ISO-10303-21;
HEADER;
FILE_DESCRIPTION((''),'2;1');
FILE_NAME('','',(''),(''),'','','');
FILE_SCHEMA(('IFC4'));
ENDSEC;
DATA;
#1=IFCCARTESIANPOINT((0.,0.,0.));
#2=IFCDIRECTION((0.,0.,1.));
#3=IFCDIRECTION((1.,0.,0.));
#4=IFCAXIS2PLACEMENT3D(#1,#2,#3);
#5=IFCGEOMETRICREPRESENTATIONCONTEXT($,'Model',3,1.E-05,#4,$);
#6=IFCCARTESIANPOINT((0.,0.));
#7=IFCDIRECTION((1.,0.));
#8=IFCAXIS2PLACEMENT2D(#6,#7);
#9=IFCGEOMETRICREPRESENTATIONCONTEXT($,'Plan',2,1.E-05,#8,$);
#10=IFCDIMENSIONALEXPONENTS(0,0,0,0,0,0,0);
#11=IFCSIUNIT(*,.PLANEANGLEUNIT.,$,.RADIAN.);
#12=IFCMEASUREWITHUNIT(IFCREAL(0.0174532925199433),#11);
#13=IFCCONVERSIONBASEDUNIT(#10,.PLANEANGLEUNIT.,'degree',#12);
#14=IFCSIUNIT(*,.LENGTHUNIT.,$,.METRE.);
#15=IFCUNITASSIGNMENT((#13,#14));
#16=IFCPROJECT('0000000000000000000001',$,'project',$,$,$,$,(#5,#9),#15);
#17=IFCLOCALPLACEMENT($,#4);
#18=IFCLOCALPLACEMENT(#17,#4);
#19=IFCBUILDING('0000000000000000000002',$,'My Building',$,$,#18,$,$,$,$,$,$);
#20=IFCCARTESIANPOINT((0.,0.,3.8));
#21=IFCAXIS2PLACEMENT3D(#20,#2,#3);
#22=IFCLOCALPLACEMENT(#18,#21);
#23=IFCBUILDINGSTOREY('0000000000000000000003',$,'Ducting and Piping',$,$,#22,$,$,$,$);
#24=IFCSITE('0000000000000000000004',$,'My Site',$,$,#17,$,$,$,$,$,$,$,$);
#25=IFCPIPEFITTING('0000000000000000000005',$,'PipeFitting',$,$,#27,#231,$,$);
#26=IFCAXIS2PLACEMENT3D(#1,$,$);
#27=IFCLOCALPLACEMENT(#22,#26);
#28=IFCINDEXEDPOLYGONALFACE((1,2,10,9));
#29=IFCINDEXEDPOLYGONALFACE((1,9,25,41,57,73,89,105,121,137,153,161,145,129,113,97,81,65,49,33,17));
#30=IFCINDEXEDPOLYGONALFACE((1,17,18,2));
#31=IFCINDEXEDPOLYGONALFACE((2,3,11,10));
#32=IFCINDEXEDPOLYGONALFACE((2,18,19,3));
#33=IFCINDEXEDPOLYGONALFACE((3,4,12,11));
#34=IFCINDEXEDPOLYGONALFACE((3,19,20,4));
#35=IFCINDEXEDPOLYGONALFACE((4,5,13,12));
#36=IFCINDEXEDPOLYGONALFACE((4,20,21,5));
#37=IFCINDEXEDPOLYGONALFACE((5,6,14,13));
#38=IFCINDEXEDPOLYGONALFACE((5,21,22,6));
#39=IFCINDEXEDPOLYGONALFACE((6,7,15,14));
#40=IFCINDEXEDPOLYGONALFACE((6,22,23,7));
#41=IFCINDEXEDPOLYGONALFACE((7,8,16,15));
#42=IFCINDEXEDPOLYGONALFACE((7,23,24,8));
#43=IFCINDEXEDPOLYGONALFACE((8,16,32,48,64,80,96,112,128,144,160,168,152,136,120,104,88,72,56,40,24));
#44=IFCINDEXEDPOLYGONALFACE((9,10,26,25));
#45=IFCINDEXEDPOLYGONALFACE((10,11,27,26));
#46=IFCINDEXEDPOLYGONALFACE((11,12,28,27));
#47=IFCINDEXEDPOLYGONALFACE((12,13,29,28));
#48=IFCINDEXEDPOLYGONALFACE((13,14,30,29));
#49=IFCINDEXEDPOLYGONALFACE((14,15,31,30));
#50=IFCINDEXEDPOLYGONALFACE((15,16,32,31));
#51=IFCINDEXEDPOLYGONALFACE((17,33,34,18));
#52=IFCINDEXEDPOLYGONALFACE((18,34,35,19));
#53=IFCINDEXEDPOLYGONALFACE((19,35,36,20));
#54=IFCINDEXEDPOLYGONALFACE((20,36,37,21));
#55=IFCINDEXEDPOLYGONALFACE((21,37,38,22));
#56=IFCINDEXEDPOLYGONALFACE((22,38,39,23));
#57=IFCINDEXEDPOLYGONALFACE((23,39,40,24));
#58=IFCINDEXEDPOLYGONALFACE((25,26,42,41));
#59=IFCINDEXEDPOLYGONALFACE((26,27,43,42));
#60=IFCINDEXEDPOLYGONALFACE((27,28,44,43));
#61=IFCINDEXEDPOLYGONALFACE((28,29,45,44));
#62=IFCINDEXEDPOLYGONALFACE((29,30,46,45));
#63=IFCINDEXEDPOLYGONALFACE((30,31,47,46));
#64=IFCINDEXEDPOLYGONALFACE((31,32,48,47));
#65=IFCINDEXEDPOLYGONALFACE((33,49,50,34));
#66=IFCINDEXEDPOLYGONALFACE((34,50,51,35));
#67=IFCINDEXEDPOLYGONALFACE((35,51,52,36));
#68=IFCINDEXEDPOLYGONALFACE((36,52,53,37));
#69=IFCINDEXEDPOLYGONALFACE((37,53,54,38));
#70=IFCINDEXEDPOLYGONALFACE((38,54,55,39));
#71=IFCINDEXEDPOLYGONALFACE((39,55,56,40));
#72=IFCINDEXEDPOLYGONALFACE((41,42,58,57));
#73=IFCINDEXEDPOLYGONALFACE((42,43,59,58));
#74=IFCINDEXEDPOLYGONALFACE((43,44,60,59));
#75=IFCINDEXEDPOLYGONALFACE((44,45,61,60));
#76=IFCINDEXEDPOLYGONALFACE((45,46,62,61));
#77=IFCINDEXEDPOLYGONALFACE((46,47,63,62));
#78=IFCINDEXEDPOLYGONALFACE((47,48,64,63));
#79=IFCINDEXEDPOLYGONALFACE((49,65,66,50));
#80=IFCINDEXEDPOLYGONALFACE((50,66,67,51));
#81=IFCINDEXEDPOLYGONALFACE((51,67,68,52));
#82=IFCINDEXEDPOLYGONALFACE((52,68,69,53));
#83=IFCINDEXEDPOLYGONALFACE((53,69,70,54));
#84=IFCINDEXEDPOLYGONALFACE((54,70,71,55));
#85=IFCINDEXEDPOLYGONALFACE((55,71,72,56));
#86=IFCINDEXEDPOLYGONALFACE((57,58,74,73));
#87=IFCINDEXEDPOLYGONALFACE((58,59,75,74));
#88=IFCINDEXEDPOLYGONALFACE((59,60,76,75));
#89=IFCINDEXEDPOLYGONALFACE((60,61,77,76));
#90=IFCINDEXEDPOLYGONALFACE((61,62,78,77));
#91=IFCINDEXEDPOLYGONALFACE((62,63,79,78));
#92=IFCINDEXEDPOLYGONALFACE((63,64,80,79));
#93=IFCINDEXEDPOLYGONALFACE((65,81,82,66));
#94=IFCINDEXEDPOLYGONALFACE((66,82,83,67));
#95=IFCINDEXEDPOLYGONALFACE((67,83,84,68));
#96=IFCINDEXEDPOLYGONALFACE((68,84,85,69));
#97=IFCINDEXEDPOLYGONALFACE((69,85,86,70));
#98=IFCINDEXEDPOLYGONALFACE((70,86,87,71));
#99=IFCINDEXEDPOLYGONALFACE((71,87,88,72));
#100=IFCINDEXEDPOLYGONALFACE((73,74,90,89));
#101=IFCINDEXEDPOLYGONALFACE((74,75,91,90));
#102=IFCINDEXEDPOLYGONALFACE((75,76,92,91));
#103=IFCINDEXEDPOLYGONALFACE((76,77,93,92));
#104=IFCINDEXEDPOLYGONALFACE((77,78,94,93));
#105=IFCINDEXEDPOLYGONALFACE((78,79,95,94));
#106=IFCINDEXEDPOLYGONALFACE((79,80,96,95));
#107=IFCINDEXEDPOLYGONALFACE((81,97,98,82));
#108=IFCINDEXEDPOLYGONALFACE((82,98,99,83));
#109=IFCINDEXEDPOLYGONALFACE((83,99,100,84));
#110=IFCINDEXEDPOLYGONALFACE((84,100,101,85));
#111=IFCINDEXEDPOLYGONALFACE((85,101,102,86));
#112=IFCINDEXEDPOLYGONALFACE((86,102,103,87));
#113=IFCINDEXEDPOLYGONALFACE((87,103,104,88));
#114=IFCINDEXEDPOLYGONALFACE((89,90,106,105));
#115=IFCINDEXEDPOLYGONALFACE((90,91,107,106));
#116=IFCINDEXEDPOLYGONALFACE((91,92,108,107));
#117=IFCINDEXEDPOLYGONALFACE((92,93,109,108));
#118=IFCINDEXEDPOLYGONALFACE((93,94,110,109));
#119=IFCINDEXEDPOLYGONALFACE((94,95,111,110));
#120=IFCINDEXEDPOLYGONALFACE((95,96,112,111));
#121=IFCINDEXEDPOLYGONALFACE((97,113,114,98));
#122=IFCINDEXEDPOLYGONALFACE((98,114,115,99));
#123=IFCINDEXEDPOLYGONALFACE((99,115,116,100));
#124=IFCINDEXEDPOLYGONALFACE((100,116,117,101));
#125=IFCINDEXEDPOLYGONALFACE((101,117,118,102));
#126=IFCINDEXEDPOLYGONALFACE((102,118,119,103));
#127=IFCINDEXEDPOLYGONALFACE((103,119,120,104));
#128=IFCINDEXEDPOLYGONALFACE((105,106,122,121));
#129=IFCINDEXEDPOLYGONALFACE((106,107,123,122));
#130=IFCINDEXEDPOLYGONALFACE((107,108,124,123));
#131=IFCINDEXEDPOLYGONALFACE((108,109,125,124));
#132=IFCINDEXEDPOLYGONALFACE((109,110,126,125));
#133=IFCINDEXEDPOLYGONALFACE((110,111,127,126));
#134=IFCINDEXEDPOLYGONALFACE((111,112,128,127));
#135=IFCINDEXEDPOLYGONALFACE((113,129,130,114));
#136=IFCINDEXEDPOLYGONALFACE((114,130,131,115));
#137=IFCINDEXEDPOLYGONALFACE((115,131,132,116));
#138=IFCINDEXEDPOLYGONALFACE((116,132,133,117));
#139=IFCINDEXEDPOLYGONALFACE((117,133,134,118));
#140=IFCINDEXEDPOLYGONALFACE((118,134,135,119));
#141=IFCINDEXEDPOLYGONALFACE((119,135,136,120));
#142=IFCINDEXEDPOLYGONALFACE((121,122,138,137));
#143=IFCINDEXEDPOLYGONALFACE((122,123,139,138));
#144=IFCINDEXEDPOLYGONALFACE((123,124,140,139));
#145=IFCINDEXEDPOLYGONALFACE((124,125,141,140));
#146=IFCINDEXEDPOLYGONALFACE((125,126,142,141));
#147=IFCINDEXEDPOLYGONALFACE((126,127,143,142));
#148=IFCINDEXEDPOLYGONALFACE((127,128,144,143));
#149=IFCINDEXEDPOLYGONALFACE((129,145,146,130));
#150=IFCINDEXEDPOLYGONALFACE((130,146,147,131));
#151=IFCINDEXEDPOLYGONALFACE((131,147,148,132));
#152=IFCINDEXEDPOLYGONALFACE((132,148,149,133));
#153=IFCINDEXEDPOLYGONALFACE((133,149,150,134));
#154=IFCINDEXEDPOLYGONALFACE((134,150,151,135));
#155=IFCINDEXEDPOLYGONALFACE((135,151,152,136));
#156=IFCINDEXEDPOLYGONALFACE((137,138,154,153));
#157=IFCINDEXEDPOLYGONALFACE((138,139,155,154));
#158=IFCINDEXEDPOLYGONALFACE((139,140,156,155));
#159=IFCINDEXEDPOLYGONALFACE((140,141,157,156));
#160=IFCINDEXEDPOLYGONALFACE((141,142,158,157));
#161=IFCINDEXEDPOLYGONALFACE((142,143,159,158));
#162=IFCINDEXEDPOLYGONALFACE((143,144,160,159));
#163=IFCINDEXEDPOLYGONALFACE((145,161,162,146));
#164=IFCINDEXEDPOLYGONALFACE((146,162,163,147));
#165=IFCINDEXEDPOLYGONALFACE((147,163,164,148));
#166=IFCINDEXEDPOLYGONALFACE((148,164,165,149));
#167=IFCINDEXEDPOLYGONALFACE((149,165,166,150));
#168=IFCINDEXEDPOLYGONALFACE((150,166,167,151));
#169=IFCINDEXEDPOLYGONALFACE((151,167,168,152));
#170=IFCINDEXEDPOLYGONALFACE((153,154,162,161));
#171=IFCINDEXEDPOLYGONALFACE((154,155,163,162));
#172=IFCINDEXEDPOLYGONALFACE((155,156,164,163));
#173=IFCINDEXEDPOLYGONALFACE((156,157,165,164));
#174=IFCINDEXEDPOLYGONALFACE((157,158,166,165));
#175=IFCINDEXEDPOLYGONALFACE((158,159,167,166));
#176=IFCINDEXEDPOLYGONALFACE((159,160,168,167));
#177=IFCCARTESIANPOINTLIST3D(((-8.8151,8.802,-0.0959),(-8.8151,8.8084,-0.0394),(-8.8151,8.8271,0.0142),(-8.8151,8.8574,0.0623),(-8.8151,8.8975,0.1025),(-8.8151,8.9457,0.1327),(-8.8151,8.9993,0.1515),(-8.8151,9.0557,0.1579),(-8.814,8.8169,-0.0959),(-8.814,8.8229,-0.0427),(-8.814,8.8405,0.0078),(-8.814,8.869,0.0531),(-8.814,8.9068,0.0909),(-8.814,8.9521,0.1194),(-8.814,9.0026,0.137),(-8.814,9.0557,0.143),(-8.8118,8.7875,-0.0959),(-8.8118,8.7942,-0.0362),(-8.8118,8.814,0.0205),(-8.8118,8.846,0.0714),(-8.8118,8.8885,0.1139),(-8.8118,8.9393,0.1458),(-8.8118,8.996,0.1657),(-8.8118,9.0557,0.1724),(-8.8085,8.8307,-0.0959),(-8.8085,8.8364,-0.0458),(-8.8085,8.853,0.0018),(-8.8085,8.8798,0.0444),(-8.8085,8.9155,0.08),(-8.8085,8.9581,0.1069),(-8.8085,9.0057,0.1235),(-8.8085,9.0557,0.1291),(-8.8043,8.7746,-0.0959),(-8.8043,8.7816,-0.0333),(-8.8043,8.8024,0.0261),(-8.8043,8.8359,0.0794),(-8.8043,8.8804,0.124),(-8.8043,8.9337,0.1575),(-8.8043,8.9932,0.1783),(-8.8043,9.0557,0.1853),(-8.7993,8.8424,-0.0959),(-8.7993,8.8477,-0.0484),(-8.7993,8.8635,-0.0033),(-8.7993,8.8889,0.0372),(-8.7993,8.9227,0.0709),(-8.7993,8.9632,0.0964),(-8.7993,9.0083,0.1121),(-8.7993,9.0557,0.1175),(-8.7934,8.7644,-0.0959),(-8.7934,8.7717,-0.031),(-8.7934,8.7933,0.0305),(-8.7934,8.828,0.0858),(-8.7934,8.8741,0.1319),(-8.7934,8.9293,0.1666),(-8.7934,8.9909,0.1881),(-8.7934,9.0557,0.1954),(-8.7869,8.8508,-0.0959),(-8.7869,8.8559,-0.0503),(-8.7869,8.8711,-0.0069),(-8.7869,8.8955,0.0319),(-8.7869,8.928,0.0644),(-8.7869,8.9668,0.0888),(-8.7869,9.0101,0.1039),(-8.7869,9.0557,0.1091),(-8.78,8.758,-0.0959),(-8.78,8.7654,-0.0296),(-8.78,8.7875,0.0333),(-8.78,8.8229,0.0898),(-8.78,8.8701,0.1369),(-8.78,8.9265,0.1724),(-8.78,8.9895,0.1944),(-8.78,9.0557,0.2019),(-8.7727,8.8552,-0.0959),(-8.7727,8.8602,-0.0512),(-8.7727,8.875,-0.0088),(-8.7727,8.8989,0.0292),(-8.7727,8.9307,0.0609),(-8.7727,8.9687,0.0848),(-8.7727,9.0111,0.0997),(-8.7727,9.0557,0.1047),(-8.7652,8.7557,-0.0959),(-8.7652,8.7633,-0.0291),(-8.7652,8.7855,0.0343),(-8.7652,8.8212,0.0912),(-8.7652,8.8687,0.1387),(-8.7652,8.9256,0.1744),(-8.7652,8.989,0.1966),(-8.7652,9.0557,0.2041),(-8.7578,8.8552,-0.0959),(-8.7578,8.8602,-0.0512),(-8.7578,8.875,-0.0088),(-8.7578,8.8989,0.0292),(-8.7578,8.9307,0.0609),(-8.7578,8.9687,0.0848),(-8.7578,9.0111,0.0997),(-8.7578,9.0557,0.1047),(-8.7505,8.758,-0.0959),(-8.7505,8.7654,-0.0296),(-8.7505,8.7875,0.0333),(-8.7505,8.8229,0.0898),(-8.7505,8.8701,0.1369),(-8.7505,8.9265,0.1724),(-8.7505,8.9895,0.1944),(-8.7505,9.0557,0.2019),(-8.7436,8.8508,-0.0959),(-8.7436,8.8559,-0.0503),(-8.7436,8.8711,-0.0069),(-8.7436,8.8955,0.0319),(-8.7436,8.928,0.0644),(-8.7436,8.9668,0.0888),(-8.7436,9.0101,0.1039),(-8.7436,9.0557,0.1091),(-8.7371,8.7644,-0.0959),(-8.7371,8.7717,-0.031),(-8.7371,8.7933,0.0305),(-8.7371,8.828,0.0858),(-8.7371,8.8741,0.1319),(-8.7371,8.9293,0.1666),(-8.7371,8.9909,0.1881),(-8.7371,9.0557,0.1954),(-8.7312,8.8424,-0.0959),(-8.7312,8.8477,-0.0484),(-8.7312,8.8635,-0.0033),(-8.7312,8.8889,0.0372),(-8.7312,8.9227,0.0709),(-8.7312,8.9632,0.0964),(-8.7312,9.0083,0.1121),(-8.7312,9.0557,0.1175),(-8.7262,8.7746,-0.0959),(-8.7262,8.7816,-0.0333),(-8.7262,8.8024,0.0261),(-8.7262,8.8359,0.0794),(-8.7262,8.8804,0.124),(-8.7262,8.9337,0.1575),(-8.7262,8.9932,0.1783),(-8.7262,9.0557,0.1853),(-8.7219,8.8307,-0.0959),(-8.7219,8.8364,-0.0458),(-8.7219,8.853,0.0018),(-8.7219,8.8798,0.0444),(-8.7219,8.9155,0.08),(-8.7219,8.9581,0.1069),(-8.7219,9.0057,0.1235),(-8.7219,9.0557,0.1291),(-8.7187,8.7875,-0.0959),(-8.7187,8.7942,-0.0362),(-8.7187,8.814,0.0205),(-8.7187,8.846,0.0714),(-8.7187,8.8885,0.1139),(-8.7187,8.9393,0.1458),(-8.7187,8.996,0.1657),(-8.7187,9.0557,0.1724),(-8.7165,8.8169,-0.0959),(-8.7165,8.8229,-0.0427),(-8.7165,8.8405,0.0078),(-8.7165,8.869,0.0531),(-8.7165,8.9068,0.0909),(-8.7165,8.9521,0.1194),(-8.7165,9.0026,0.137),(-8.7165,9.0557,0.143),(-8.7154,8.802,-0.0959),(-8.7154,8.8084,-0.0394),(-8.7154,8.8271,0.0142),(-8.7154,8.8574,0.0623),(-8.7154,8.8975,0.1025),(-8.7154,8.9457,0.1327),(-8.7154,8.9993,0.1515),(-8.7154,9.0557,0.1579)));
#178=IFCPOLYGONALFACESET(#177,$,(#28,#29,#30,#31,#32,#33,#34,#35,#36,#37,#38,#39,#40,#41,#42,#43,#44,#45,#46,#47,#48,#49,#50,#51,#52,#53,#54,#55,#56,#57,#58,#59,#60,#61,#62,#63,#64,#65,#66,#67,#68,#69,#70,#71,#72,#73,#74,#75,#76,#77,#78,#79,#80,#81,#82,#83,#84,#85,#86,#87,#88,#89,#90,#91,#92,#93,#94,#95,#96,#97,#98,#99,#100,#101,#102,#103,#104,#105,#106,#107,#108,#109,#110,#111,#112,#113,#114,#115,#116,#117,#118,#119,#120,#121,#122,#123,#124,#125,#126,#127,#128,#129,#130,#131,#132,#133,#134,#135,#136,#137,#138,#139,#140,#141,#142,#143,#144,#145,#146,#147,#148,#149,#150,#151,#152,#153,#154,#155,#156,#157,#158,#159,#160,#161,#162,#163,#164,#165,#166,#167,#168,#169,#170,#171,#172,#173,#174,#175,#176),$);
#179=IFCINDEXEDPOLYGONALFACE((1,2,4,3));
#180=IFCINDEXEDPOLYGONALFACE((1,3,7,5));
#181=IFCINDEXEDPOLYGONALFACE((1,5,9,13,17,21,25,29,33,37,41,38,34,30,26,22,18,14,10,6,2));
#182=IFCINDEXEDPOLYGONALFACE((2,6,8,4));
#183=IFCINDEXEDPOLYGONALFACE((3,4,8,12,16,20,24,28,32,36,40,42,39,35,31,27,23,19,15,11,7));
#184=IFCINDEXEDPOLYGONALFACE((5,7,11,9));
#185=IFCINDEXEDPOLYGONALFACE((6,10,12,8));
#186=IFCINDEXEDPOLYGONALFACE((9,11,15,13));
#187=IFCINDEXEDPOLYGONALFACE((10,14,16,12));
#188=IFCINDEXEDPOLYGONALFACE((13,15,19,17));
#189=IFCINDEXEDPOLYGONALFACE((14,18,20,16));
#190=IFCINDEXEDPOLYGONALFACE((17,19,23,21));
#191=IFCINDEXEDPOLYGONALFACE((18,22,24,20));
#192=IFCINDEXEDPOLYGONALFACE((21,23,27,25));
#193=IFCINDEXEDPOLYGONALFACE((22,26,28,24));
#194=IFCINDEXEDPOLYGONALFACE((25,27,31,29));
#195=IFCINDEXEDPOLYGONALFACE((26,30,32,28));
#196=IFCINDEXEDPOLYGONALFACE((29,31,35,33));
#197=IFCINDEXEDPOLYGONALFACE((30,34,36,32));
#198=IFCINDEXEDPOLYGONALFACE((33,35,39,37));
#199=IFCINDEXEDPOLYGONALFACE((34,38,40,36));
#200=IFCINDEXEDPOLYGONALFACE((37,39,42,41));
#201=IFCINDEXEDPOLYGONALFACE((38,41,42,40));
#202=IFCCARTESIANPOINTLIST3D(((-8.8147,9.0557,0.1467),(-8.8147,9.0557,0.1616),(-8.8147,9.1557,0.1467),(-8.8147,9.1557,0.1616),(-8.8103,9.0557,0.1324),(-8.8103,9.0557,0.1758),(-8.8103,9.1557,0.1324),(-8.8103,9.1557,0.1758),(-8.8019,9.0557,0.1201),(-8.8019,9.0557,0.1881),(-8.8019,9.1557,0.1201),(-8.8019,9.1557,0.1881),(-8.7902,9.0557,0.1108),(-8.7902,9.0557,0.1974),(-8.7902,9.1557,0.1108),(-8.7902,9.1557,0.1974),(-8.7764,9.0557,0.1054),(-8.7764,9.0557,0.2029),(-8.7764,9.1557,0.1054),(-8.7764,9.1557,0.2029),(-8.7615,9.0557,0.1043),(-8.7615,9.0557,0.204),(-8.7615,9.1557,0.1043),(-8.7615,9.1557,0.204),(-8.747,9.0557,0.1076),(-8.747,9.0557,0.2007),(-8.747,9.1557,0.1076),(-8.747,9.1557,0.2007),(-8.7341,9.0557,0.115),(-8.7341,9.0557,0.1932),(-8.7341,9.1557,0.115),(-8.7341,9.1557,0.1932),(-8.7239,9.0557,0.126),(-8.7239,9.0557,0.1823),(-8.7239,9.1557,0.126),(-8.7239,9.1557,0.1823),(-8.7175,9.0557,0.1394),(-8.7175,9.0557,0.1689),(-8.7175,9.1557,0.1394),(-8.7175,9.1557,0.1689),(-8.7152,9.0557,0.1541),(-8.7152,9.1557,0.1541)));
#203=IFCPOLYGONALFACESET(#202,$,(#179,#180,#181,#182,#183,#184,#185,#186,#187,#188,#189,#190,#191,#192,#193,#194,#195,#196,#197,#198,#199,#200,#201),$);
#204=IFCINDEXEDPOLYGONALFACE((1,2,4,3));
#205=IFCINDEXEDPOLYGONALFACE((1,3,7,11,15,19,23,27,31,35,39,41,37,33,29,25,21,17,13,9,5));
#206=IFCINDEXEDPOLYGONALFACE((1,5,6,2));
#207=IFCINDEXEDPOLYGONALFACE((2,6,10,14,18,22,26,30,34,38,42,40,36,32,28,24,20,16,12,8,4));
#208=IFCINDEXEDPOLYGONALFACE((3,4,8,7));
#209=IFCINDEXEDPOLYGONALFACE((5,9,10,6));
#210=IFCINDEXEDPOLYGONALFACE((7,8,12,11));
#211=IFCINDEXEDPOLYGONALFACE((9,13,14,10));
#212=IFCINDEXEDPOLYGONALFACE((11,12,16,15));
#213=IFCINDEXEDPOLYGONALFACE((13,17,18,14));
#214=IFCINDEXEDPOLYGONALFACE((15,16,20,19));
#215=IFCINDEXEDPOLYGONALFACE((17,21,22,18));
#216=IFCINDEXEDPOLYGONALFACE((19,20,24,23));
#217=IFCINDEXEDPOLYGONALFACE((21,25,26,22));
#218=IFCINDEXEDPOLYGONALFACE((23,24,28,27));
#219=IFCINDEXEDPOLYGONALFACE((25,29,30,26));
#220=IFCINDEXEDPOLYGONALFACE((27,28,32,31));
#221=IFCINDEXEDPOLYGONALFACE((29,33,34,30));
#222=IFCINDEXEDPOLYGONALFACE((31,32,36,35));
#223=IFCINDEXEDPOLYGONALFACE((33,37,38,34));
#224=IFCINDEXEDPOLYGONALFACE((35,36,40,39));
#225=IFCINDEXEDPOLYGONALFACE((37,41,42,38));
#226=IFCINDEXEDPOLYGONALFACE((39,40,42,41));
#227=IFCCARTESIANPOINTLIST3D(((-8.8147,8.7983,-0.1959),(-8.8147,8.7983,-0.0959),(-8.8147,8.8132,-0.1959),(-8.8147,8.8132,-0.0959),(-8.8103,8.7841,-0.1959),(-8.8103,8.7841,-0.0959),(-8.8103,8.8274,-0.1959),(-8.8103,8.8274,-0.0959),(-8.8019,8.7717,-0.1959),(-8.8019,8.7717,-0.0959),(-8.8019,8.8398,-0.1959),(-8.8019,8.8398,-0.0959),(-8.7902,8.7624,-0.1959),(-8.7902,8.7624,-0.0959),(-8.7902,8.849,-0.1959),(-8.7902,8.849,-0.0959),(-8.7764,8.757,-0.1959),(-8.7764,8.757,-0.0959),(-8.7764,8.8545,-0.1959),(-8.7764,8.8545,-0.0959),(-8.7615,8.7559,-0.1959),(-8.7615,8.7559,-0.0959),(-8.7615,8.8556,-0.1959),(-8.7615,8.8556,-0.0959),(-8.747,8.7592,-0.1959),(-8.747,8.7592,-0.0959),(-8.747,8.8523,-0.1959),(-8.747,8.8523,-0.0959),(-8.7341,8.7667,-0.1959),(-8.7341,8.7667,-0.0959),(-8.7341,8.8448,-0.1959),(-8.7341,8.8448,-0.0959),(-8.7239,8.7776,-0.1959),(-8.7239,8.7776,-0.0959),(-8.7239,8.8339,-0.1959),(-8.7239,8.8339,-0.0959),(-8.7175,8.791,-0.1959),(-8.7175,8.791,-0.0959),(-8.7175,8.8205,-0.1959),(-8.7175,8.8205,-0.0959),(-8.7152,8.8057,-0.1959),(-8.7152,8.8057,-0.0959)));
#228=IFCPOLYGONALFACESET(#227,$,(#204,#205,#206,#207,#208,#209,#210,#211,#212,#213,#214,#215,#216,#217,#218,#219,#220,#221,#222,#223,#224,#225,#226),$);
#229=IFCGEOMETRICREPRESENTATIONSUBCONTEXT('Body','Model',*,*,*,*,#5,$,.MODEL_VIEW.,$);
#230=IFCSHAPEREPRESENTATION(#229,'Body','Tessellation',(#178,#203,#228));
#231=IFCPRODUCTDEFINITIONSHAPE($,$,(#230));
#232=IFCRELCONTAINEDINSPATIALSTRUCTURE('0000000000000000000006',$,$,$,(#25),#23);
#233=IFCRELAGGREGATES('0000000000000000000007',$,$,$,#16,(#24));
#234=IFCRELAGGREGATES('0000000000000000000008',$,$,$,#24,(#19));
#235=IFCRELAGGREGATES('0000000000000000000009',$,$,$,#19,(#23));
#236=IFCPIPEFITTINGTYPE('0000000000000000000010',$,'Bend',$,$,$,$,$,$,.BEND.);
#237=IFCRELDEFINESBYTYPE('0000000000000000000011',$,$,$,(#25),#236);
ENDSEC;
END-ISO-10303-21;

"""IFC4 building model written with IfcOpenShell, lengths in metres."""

from ifc_helpers import new_model, entity, si_unit, converted_unit, frame, origin_with_axes, origin_2d_with_axis, place, context, subcontext, project, spatial, circle, extrude, source, transform, mapped, type_object, type_shapes, element, save


model = new_model("IFC4")

# Units and contexts
model_context = context("Model", 3, precision=1e-05, world=origin_with_axes())
plan_context = context("Plan", 2, precision=1e-05, world=origin_2d_with_axis())
body_context = subcontext(model_context, "Body", "Model", "MODEL_VIEW")
ifc_project = project(units=[converted_unit("PLANEANGLEUNIT", "degree", entity("IfcReal", 0.0174532925199433), si_unit("PLANEANGLEUNIT", "RADIAN"), dimensions=[0, 0, 0, 0, 0, 0, 0]), si_unit("LENGTHUNIT", "METRE")], contexts=[model_context, plan_context])

# Site, building, storey
site_placement = place(None, origin_with_axes())
site = spatial("IfcSite", under=ifc_project, at=site_placement, Name="My Site")
building_placement = place(site_placement, origin_with_axes())
building = spatial("IfcBuilding", under=site, at=building_placement, Name="My Building")
storey_placement = place(building_placement, frame((0.0, 0.0, 3.8), z_axis=(0.0, 0.0, 1.0), x_axis=(1.0, 0.0, 0.0)))
storey = spatial("IfcBuildingStorey", under=building, at=storey_placement, Name="Ducting and Piping")

# Pipe fitting
pipe_fitting_type = type_object("IfcPipeFittingType", Name="Bend", PredefinedType="BEND")
shared_shape = source(origin_with_axes(), body_context, "Body", "SolidModel", [
    entity("IfcSweptDiskSolid", entity("IfcIndexedPolyCurve", entity("IfcCartesianPointList3D", [[0.0, 0.0, 0.1], [0.0, -0.0732, 0.2768], [0.0, -0.25, 0.35]]), [entity("IfcArcIndex", [1, 2, 3])]), 0.05),
    extrude(circle(Radius=0.05), origin_with_axes(), (0.0, 0.0, 1.0), 0.1),
    extrude(circle(Radius=0.05), frame((0.0, -0.25, 0.35), z_axis=(0.0, -1.0, 0.0), x_axis=(1.0, 0.0, 0.0)), (0.0, 0.0, 1.0), 0.1),
])
type_shapes(pipe_fitting_type, [shared_shape])
for number, where, z_axis, x_axis, name in (
    (1, (-8.7652, 9.1557, 0.1541), (0.0, -1.0, 0.0), (1.0, 0.0, 0.0), "PipeFitting"),
):
    element("IfcPipeFitting", number, at=place(storey_placement, frame(where, z_axis=z_axis, x_axis=x_axis)), inside=storey, type_object=pipe_fitting_type, Name=name, context=body_context, shape_type="MappedRepresentation", body=[
        mapped(shared_shape, transform((0.0, 0.0, 0.0), x_axis=(1.0, 0.0, 0.0), y_axis=(0.0, 1.0, 0.0), z_axis=(0.0, 0.0, 1.0), scale=1.0)),
    ])

save(model, "model.ifc")
